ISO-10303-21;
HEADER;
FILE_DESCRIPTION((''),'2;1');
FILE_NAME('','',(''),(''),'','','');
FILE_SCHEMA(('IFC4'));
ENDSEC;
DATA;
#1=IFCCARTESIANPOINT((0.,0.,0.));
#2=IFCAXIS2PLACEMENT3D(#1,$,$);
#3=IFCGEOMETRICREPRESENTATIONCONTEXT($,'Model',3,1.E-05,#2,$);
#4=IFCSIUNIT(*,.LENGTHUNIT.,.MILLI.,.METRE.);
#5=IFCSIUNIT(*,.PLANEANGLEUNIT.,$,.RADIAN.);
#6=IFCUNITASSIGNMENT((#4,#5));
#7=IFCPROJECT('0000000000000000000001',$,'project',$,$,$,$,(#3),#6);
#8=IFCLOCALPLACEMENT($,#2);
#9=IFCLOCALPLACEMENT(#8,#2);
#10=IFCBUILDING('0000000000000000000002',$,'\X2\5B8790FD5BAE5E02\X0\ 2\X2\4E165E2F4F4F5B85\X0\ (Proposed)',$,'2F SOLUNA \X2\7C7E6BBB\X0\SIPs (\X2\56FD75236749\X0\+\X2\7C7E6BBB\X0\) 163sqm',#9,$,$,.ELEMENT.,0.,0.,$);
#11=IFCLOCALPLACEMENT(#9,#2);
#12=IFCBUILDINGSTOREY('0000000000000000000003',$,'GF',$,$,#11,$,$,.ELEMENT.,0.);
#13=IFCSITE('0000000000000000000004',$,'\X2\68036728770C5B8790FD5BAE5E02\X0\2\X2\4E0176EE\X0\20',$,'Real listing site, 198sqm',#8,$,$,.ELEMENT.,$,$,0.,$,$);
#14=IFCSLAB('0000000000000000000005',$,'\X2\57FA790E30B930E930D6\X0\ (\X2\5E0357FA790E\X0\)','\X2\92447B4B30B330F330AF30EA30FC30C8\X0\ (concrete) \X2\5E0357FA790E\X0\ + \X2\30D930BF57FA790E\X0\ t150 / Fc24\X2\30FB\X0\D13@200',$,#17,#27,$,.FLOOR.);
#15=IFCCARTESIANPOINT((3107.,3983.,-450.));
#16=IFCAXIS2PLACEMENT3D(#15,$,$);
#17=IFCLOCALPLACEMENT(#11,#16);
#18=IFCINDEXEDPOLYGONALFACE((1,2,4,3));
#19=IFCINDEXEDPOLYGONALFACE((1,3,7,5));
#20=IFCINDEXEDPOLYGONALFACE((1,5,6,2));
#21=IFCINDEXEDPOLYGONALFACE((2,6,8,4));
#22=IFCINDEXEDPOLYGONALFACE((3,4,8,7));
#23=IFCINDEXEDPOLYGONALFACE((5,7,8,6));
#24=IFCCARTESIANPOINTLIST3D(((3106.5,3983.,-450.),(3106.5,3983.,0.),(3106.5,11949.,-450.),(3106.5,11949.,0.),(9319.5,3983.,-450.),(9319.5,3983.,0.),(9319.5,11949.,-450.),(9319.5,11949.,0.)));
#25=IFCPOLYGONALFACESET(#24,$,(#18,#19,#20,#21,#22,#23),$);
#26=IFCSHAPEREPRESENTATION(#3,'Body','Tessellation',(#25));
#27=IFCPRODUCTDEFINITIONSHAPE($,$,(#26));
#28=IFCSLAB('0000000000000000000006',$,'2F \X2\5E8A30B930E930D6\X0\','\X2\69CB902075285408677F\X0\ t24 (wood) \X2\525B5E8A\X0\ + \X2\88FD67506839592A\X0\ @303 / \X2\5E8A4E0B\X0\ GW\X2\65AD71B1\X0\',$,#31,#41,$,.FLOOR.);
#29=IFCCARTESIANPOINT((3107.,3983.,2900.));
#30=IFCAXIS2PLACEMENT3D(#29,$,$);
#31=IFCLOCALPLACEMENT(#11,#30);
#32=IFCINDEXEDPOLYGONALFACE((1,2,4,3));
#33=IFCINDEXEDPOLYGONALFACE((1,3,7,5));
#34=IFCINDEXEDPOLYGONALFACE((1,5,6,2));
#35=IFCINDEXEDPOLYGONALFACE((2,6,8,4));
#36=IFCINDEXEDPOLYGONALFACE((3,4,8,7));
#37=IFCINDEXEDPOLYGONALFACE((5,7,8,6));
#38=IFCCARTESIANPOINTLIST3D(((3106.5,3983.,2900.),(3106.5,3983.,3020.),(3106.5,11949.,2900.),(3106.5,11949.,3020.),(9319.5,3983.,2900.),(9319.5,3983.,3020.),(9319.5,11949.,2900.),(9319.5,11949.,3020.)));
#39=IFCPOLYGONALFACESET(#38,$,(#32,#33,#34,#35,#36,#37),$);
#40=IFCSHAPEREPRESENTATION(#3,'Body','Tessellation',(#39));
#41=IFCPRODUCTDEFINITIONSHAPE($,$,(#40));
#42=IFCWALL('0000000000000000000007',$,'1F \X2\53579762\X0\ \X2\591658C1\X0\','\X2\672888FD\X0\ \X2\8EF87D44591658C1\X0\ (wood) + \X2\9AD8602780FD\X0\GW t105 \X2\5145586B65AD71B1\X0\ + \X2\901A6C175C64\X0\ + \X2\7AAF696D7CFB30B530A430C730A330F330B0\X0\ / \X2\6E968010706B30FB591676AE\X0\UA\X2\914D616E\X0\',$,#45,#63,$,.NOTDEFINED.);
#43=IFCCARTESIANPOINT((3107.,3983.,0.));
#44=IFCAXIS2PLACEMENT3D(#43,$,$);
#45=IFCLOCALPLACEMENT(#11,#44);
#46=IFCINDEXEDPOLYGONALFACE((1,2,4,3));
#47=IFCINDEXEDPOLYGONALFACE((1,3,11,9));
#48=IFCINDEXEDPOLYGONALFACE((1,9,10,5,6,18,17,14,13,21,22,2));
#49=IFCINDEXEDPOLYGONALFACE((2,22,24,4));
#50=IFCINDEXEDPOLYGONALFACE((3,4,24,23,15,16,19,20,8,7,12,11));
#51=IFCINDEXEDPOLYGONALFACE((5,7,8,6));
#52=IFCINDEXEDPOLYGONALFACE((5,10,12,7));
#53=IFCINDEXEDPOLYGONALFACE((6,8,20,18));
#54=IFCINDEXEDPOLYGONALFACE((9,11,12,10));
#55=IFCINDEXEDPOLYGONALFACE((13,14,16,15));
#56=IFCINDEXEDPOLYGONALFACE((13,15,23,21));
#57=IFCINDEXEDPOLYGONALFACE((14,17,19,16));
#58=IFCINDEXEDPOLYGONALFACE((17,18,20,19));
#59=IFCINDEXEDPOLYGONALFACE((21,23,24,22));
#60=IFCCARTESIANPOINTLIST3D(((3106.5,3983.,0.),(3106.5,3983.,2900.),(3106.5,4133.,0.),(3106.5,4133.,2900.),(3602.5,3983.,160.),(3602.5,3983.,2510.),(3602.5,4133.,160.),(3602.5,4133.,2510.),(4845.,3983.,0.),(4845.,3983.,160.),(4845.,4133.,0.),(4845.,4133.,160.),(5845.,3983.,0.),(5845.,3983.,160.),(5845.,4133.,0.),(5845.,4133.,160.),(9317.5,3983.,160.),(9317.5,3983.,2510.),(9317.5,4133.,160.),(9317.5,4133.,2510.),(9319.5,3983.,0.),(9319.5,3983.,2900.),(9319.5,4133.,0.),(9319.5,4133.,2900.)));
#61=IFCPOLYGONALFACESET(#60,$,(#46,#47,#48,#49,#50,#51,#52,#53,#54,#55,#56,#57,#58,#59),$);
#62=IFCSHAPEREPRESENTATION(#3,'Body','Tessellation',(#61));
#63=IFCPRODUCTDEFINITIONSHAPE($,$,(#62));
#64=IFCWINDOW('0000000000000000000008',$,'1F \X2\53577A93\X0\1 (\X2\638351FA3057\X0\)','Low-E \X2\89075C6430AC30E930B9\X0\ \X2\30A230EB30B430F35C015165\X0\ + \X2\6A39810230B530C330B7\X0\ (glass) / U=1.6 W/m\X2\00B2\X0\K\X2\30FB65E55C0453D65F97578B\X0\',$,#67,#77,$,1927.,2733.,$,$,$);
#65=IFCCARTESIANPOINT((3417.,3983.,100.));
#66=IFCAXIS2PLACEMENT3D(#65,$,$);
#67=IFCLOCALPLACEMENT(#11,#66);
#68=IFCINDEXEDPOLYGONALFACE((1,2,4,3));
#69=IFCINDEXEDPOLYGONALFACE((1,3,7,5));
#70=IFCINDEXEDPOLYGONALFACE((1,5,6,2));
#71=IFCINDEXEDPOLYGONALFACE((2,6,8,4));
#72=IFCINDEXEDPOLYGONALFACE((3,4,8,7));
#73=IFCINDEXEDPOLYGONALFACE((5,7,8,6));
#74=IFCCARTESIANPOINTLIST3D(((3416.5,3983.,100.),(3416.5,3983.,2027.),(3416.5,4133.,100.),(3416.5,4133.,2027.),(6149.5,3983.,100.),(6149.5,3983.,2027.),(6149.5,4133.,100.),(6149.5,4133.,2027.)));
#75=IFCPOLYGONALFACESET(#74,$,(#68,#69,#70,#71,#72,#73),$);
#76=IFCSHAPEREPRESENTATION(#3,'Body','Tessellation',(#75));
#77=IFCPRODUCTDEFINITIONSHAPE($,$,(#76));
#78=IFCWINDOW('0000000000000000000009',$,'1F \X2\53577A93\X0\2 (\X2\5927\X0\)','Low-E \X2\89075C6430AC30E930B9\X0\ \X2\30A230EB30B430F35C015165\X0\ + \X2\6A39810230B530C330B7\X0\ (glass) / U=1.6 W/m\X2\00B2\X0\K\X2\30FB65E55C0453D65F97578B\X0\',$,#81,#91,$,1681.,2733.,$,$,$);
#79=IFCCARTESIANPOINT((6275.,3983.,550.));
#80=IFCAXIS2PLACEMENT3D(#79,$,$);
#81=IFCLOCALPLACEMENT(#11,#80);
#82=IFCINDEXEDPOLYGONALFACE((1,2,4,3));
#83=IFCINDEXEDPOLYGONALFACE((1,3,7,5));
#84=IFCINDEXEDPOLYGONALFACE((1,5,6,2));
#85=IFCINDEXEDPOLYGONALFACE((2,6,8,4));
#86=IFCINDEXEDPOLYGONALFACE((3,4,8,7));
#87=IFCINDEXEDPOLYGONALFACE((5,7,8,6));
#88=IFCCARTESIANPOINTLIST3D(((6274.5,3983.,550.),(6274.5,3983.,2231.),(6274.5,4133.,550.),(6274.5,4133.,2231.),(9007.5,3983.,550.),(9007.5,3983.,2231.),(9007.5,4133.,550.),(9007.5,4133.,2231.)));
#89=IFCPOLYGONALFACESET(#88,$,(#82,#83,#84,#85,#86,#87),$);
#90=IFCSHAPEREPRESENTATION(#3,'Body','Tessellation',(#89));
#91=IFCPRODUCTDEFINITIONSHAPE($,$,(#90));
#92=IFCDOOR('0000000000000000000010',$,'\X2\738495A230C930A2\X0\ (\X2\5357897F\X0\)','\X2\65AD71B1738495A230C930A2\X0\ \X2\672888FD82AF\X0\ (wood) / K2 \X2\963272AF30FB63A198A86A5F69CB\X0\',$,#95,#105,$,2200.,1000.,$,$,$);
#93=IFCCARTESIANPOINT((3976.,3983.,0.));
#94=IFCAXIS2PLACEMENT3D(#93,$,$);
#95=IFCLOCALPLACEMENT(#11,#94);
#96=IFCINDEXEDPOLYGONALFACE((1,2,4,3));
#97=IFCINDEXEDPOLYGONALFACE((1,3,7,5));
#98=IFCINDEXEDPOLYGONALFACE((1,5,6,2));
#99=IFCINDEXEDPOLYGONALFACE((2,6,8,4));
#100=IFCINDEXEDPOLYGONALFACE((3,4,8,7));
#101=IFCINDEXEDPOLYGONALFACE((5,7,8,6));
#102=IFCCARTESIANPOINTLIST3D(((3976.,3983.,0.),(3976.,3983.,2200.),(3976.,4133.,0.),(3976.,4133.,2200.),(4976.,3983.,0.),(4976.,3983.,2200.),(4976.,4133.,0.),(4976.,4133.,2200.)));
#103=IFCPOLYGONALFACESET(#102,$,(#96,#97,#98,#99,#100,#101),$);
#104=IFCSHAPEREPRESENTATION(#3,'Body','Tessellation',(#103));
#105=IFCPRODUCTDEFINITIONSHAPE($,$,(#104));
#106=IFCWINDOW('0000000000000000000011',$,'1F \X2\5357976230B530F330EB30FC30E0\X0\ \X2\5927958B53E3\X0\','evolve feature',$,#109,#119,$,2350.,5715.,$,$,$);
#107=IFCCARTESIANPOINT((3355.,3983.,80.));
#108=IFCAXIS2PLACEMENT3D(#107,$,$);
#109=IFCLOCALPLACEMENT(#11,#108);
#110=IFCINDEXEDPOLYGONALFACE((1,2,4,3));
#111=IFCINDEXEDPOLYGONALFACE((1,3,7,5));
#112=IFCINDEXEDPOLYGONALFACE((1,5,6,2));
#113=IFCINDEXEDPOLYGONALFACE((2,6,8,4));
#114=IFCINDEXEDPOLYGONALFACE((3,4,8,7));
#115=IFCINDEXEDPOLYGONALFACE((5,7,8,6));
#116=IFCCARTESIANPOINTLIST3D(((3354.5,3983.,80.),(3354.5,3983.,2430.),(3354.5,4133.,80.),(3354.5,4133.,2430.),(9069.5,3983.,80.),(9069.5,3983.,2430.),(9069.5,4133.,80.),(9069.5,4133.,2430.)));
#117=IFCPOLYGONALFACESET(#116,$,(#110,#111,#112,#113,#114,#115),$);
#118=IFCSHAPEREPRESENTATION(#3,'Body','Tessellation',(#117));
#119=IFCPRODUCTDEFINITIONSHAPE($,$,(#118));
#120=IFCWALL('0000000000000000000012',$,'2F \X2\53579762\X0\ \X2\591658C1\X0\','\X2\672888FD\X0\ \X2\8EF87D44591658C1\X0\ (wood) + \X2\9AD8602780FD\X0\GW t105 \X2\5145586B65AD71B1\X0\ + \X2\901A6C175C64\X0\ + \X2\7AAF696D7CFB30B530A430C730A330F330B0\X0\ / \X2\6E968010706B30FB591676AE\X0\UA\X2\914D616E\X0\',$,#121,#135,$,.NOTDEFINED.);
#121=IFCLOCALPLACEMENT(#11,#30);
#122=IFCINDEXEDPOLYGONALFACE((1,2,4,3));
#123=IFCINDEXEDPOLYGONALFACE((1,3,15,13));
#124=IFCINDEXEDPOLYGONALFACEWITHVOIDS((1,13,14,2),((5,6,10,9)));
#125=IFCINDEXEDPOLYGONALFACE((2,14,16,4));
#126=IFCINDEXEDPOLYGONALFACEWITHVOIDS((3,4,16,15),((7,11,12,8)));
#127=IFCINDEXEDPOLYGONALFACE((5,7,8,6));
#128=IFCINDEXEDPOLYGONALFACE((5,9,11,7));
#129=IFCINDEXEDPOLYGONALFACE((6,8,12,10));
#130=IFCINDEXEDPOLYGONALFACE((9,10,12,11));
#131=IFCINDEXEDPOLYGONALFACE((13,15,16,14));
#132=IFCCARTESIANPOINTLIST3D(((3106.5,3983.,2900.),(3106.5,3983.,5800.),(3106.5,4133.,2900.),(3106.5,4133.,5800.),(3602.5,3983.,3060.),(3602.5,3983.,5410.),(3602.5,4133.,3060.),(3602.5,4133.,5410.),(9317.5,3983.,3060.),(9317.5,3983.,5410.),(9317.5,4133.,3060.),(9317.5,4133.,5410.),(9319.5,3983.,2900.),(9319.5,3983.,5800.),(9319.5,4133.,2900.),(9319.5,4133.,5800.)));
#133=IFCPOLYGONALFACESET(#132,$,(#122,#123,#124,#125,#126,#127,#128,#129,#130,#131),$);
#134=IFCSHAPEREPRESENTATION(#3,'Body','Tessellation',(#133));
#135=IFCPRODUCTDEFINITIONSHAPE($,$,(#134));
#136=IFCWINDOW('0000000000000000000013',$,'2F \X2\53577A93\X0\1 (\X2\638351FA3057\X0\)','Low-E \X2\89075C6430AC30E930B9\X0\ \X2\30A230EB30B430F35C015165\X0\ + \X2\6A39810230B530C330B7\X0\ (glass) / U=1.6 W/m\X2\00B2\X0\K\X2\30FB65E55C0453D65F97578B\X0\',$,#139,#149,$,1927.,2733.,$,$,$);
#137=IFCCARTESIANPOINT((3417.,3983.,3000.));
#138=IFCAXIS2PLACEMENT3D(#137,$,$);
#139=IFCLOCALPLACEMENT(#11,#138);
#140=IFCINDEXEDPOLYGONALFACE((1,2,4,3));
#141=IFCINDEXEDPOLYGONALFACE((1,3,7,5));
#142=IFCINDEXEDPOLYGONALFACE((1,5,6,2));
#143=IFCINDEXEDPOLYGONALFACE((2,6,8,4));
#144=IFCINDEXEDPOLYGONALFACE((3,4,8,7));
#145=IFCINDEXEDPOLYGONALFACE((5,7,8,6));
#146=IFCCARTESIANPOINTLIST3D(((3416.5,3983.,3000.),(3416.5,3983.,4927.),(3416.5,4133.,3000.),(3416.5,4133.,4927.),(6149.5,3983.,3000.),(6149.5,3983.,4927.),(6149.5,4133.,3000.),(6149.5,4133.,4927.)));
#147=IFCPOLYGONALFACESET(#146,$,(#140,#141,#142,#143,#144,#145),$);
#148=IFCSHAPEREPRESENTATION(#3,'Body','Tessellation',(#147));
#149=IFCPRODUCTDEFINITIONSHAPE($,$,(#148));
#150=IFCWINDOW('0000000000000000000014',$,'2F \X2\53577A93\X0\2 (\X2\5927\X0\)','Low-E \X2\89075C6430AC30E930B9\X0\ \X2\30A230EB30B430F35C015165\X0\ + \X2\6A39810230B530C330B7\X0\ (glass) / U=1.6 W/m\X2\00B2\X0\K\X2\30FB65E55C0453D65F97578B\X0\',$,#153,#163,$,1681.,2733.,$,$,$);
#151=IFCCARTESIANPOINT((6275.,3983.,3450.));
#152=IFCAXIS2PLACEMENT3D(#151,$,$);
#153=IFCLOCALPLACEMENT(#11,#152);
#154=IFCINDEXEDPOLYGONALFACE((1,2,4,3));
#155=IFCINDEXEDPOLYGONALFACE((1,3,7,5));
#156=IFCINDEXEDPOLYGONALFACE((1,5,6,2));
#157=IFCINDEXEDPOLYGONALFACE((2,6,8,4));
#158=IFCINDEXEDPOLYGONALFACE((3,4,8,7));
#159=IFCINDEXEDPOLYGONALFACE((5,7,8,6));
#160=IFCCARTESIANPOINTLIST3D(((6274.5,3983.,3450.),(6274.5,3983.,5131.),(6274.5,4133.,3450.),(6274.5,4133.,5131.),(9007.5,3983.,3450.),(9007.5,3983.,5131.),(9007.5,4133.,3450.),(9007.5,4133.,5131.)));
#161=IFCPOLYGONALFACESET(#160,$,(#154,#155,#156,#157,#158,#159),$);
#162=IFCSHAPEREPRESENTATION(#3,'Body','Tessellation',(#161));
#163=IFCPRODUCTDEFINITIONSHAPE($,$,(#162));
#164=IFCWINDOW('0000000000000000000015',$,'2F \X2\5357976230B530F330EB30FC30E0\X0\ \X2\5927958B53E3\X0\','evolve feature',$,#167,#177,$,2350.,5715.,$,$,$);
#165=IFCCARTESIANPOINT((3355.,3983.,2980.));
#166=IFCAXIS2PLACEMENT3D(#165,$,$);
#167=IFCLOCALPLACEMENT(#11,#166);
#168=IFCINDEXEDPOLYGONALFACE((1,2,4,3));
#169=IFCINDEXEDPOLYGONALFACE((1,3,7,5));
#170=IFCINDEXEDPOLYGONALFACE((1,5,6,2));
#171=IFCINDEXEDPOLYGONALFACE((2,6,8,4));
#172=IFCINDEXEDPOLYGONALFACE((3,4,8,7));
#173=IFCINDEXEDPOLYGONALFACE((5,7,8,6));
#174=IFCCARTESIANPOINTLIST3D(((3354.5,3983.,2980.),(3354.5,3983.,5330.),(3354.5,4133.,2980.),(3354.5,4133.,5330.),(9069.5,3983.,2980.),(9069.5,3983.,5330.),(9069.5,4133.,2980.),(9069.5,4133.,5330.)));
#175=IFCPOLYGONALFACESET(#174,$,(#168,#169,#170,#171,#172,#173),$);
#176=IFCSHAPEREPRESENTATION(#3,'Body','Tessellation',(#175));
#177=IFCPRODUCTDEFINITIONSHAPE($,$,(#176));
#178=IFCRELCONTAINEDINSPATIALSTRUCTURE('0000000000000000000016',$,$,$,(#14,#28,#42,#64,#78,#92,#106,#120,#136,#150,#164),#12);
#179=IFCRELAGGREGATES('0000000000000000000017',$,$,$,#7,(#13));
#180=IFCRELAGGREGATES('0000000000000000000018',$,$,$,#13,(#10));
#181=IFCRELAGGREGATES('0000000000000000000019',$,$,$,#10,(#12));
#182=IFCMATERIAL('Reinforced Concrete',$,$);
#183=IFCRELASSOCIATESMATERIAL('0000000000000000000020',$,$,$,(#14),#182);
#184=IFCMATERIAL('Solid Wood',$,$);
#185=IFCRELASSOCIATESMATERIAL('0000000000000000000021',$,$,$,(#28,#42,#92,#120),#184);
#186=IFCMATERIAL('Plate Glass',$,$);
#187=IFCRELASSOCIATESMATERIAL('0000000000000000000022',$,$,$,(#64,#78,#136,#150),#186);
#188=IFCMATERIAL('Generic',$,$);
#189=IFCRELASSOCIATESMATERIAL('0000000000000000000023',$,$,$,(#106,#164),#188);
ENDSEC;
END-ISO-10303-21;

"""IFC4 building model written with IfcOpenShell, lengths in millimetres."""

from ifc_helpers import new_model, si_unit, frame, frame_2d, origin, place, context, project, spatial, rectangle, extrude, material, element, fill, save


model = new_model("IFC4")

# Units and contexts
model_context = context("Model", 3, precision=1e-05, world=origin())
ifc_project = project(units=[si_unit("LENGTHUNIT", "METRE", prefix="MILLI"), si_unit("PLANEANGLEUNIT", "RADIAN")], contexts=[model_context])

# Site, building, storey
site_placement = place(None, origin())
site = spatial("IfcSite", under=ifc_project, at=site_placement, Name="栃木県宇都宮市2丁目20", ObjectType="Real listing site, 198sqm", CompositionType="ELEMENT", RefElevation=0.0)
building_placement = place(site_placement, origin())
building = spatial("IfcBuilding", under=site, at=building_placement, Name="宇都宮市 2世帯住宅 (Proposed)", ObjectType="2F SOLUNA 籾殻SIPs (国産杉+籾殻) 163sqm", CompositionType="ELEMENT", ElevationOfRefHeight=0.0, ElevationOfTerrain=0.0)
storey_placement = place(building_placement, origin())
storey = spatial("IfcBuildingStorey", under=building, at=storey_placement, Name="GF", CompositionType="ELEMENT", Elevation=0.0)

# Slabs
ifc_material_1 = material(Name="Reinforced Concrete")
slab_1_placement = place(storey_placement, frame((3107.0, 3983.0, -450.0)))
element("IfcSlab", 1, at=slab_1_placement, inside=storey, material=ifc_material_1, Name="基礎スラブ (布基礎)", Description="鉄筋コンクリート (concrete) 布基礎 + ベタ基礎 t150 / Fc24・D13@200", PredefinedType="FLOOR", context=model_context, shape_type="SweptSolid", body=[
    extrude(rectangle(XDim=6213.0, YDim=7966.0, at=frame_2d((3106.0, 3983.0))), frame((3107.0, 3983.0, -450.0)), (0.0, 0.0, 1.0), 450.0),
])
ifc_material_2 = material(Name="Solid Wood")
slab_2_placement = place(storey_placement, frame((3107.0, 3983.0, 2900.0)))
element("IfcSlab", 2, at=slab_2_placement, inside=storey, material=ifc_material_2, Name="2F 床スラブ", Description="構造用合板 t24 (wood) 剛床 + 製材根太 @303 / 床下 GW断熱", PredefinedType="FLOOR", context=model_context, shape_type="SweptSolid", body=[
    extrude(rectangle(XDim=6213.0, YDim=7966.0, at=frame_2d((3106.0, 3983.0))), frame((3107.0, 3983.0, 2900.0)), (0.0, 0.0, 1.0), 120.0),
])
ifc_material_3 = material(Name="Generic")

# Wall, openings, windows, door
wall_1_placement = place(storey_placement, frame((3107.0, 3983.0, 0.0)))
wall_1 = element("IfcWall", 3, at=wall_1_placement, inside=storey, material=ifc_material_2, Name="1F 南面 外壁", Description="木製 軸組外壁 (wood) + 高性能GW t105 充填断熱 + 通気層 + 窯業系サイディング / 準耐火・外皮UA配慮", PredefinedType="NOTDEFINED", context=model_context, shape_type="SweptSolid", body=[
    extrude(rectangle(XDim=6213.0, YDim=150.0, at=frame_2d((3106.0, 75.0))), frame((3107.0, 3983.0, 0.0)), (0.0, 0.0, 1.0), 2900.0),
])
opening_1_placement = place(storey_placement, frame((3417.0, 3983.0, 100.0)))
opening_1 = element("IfcOpeningElement", 4, at=opening_1_placement, cuts=wall_1, PredefinedType="NOTDEFINED", context=model_context, shape_type="SweptSolid", body=[
    extrude(rectangle(XDim=2733.0, YDim=150.0, at=frame_2d((1366.0, 75.0))), frame((3417.0, 3983.0, 100.0)), (0.0, 0.0, 1.0), 1927.0),
])
opening_2_placement = place(storey_placement, frame((6275.0, 3983.0, 550.0)))
opening_2 = element("IfcOpeningElement", 5, at=opening_2_placement, cuts=wall_1, PredefinedType="NOTDEFINED", context=model_context, shape_type="SweptSolid", body=[
    extrude(rectangle(XDim=2733.0, YDim=150.0, at=frame_2d((1366.0, 75.0))), frame((6275.0, 3983.0, 550.0)), (0.0, 0.0, 1.0), 1681.0),
])
opening_3_placement = place(storey_placement, frame((3976.0, 3983.0, 0.0)))
opening_3 = element("IfcOpeningElement", 6, at=opening_3_placement, cuts=wall_1, PredefinedType="NOTDEFINED", context=model_context, shape_type="SweptSolid", body=[
    extrude(rectangle(XDim=1000.0, YDim=150.0, at=frame_2d((500.0, 75.0))), frame((3976.0, 3983.0, 0.0)), (0.0, 0.0, 1.0), 2200.0),
])
opening_4_placement = place(storey_placement, frame((3355.0, 3983.0, 80.0)))
opening_4 = element("IfcOpeningElement", 7, at=opening_4_placement, cuts=wall_1, PredefinedType="NOTDEFINED", context=model_context, shape_type="SweptSolid", body=[
    extrude(rectangle(XDim=5715.0, YDim=150.0, at=frame_2d((2857.0, 75.0))), frame((3355.0, 3983.0, 80.0)), (0.0, 0.0, 1.0), 2350.0),
])
ifc_material_4 = material(Name="Plate Glass")
window_1_placement = place(storey_placement, frame((3417.0, 3983.0, 100.0)))
window_1 = element("IfcWindow", 8, at=window_1_placement, inside=storey, material=ifc_material_4, Name="1F 南窓1 (掃出し)", Description="Low-E 複層ガラス アルゴン封入 + 樹脂サッシ (glass) / U=1.6 W/m²K・日射取得型", OverallHeight=1927.0, OverallWidth=2733.0, context=model_context, shape_type="SweptSolid", body=[
    extrude(rectangle(XDim=2733.0, YDim=150.0, at=frame_2d((1366.0, 75.0))), frame((3417.0, 3983.0, 100.0)), (0.0, 0.0, 1.0), 1927.0),
])
fill(opening_1, window_1)
window_2_placement = place(storey_placement, frame((6275.0, 3983.0, 550.0)))
window_2 = element("IfcWindow", 9, at=window_2_placement, inside=storey, material=ifc_material_4, Name="1F 南窓2 (大)", Description="Low-E 複層ガラス アルゴン封入 + 樹脂サッシ (glass) / U=1.6 W/m²K・日射取得型", OverallHeight=1681.0, OverallWidth=2733.0, context=model_context, shape_type="SweptSolid", body=[
    extrude(rectangle(XDim=2733.0, YDim=150.0, at=frame_2d((1366.0, 75.0))), frame((6275.0, 3983.0, 550.0)), (0.0, 0.0, 1.0), 1681.0),
])
fill(opening_2, window_2)
door_placement = place(storey_placement, frame((3976.0, 3983.0, 0.0)))
door = element("IfcDoor", 10, at=door_placement, inside=storey, material=ifc_material_2, Name="玄関ドア (南西)", Description="断熱玄関ドア 木製芯 (wood) / K2 防犯・採風機構", OverallHeight=2200.0, OverallWidth=1000.0, context=model_context, shape_type="SweptSolid", body=[
    extrude(rectangle(XDim=1000.0, YDim=150.0, at=frame_2d((500.0, 75.0))), frame((3976.0, 3983.0, 0.0)), (0.0, 0.0, 1.0), 2200.0),
])
fill(opening_3, door)
window_3_placement = place(storey_placement, frame((3355.0, 3983.0, 80.0)))
window_3 = element("IfcWindow", 11, at=window_3_placement, inside=storey, material=ifc_material_3, Name="1F 南面サンルーム 大開口", Description="evolve feature", OverallHeight=2350.0, OverallWidth=5715.0, context=model_context, shape_type="SweptSolid", body=[
    extrude(rectangle(XDim=5715.0, YDim=150.0, at=frame_2d((2857.0, 75.0))), frame((3355.0, 3983.0, 80.0)), (0.0, 0.0, 1.0), 2350.0),
])
fill(opening_4, window_3)

# Wall, openings, windows
wall_2_placement = place(storey_placement, frame((3107.0, 3983.0, 2900.0)))
wall_2 = element("IfcWall", 12, at=wall_2_placement, inside=storey, material=ifc_material_2, Name="2F 南面 外壁", Description="木製 軸組外壁 (wood) + 高性能GW t105 充填断熱 + 通気層 + 窯業系サイディング / 準耐火・外皮UA配慮", PredefinedType="NOTDEFINED", context=model_context, shape_type="SweptSolid", body=[
    extrude(rectangle(XDim=6213.0, YDim=150.0, at=frame_2d((3106.0, 75.0))), frame((3107.0, 3983.0, 2900.0)), (0.0, 0.0, 1.0), 2900.0),
])
opening_5_placement = place(storey_placement, frame((3417.0, 3983.0, 3000.0)))
opening_5 = element("IfcOpeningElement", 13, at=opening_5_placement, cuts=wall_2, PredefinedType="NOTDEFINED", context=model_context, shape_type="SweptSolid", body=[
    extrude(rectangle(XDim=2733.0, YDim=150.0, at=frame_2d((1366.0, 75.0))), frame((3417.0, 3983.0, 3000.0)), (0.0, 0.0, 1.0), 1927.0),
])
opening_6_placement = place(storey_placement, frame((6275.0, 3983.0, 3450.0)))
opening_6 = element("IfcOpeningElement", 14, at=opening_6_placement, cuts=wall_2, PredefinedType="NOTDEFINED", context=model_context, shape_type="SweptSolid", body=[
    extrude(rectangle(XDim=2733.0, YDim=150.0, at=frame_2d((1366.0, 75.0))), frame((6275.0, 3983.0, 3450.0)), (0.0, 0.0, 1.0), 1681.0),
])
opening_7_placement = place(storey_placement, frame((3355.0, 3983.0, 2980.0)))
opening_7 = element("IfcOpeningElement", 15, at=opening_7_placement, cuts=wall_2, PredefinedType="NOTDEFINED", context=model_context, shape_type="SweptSolid", body=[
    extrude(rectangle(XDim=5715.0, YDim=150.0, at=frame_2d((2857.0, 75.0))), frame((3355.0, 3983.0, 2980.0)), (0.0, 0.0, 1.0), 2350.0),
])
window_4_placement = place(storey_placement, frame((3417.0, 3983.0, 3000.0)))
window_4 = element("IfcWindow", 16, at=window_4_placement, inside=storey, material=ifc_material_4, Name="2F 南窓1 (掃出し)", Description="Low-E 複層ガラス アルゴン封入 + 樹脂サッシ (glass) / U=1.6 W/m²K・日射取得型", OverallHeight=1927.0, OverallWidth=2733.0, context=model_context, shape_type="SweptSolid", body=[
    extrude(rectangle(XDim=2733.0, YDim=150.0, at=frame_2d((1366.0, 75.0))), frame((3417.0, 3983.0, 3000.0)), (0.0, 0.0, 1.0), 1927.0),
])
fill(opening_5, window_4)
window_5_placement = place(storey_placement, frame((6275.0, 3983.0, 3450.0)))
window_5 = element("IfcWindow", 17, at=window_5_placement, inside=storey, material=ifc_material_4, Name="2F 南窓2 (大)", Description="Low-E 複層ガラス アルゴン封入 + 樹脂サッシ (glass) / U=1.6 W/m²K・日射取得型", OverallHeight=1681.0, OverallWidth=2733.0, context=model_context, shape_type="SweptSolid", body=[
    extrude(rectangle(XDim=2733.0, YDim=150.0, at=frame_2d((1366.0, 75.0))), frame((6275.0, 3983.0, 3450.0)), (0.0, 0.0, 1.0), 1681.0),
])
fill(opening_6, window_5)
window_6_placement = place(storey_placement, frame((3355.0, 3983.0, 2980.0)))
window_6 = element("IfcWindow", 18, at=window_6_placement, inside=storey, material=ifc_material_3, Name="2F 南面サンルーム 大開口", Description="evolve feature", OverallHeight=2350.0, OverallWidth=5715.0, context=model_context, shape_type="SweptSolid", body=[
    extrude(rectangle(XDim=5715.0, YDim=150.0, at=frame_2d((2857.0, 75.0))), frame((3355.0, 3983.0, 2980.0)), (0.0, 0.0, 1.0), 2350.0),
])
fill(opening_7, window_6)

save(model, "model.ifc")
